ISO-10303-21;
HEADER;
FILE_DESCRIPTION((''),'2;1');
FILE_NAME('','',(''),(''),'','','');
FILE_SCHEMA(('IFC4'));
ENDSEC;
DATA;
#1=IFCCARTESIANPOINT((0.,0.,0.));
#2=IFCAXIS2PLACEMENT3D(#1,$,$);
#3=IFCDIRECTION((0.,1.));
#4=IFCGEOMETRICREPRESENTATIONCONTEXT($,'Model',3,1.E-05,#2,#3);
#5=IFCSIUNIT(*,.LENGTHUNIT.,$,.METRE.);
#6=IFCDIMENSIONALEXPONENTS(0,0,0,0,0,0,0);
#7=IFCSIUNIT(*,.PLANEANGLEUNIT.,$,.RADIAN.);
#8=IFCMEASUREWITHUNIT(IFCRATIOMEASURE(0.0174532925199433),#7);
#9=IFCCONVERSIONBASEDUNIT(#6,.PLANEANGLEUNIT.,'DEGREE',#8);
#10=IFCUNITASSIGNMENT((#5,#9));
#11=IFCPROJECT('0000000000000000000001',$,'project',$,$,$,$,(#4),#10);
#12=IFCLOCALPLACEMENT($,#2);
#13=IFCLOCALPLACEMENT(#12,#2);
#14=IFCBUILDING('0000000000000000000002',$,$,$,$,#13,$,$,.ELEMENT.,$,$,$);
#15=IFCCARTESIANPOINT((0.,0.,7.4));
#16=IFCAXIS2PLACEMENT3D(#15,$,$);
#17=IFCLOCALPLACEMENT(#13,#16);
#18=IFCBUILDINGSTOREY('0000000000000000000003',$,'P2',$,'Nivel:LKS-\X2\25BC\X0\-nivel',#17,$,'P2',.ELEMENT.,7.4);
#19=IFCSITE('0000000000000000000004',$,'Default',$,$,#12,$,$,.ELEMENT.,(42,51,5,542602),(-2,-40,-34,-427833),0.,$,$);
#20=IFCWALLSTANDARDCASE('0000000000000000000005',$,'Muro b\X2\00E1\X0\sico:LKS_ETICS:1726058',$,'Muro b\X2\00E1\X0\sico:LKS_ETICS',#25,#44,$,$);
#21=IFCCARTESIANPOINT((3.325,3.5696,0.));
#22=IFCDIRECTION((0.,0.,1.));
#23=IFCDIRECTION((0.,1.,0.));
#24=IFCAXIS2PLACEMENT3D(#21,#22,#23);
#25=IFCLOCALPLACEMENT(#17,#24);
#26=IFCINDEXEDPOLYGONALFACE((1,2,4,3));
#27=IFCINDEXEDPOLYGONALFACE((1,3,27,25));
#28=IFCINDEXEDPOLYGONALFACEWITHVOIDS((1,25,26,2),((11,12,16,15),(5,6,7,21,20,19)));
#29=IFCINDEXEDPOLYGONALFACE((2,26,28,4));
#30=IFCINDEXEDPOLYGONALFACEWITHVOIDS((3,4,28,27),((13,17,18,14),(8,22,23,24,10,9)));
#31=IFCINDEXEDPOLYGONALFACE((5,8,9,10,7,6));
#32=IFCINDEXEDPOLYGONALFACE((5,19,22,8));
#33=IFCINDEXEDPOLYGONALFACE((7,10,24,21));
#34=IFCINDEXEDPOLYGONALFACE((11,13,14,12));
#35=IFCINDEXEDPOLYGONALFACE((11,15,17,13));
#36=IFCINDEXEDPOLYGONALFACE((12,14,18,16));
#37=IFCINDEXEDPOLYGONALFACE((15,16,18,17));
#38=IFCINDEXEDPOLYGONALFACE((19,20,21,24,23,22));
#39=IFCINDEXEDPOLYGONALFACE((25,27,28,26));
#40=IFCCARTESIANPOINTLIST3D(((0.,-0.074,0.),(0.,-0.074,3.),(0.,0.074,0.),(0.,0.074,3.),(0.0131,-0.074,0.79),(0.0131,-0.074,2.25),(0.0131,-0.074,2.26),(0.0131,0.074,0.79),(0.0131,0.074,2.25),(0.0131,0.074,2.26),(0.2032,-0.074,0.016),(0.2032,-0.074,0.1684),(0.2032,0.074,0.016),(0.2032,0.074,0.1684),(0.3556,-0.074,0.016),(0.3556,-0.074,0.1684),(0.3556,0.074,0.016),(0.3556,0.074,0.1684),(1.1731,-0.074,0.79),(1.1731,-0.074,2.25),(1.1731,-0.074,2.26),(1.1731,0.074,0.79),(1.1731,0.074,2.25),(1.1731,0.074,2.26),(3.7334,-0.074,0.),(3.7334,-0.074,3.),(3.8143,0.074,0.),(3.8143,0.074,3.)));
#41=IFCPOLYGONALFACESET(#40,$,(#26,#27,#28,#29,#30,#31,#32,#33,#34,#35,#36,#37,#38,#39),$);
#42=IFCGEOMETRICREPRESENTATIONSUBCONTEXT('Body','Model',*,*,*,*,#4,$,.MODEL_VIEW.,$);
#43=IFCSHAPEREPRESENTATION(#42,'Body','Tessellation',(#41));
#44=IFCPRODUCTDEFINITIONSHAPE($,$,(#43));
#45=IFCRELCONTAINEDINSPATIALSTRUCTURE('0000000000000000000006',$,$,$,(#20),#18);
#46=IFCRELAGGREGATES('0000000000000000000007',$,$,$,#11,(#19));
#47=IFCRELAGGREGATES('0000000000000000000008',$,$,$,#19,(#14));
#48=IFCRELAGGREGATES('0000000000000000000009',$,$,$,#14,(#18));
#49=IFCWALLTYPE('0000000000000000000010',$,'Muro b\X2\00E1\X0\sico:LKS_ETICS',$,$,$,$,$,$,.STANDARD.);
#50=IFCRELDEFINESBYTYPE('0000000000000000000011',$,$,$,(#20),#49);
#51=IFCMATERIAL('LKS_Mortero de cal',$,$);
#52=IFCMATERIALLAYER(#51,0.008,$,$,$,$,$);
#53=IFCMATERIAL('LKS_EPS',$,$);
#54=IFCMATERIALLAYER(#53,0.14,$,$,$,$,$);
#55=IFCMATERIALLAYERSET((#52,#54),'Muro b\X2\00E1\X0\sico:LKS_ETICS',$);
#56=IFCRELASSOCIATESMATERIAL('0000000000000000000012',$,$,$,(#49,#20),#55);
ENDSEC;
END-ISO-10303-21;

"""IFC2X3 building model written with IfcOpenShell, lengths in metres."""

from ifc_helpers import new_model, entity, si_unit, converted_unit, direction, frame, frame_2d, origin, place, context, subcontext, project, spatial, polyline, rectangle, outline, extrude, material, layer, layer_set, layer_usage, type_object, element, save


model = new_model("IFC2X3")

# Units and contexts
model_context = context("Model", 3, precision=1e-05, world=origin(), true_north=direction((0.0, 1.0)))
body_context = subcontext(model_context, "Body", "Model", "MODEL_VIEW")
ifc_project = project(units=[si_unit("LENGTHUNIT", "METRE"), converted_unit("PLANEANGLEUNIT", "DEGREE", entity("IfcRatioMeasure", 0.0174532925199433), si_unit("PLANEANGLEUNIT", "RADIAN"), dimensions=[0, 0, 0, 0, 0, 0, 0])], contexts=[model_context])

# Site, building, storey
site_placement = place(None, origin())
site = spatial("IfcSite", under=ifc_project, at=site_placement, Name="Default", CompositionType="ELEMENT", RefLatitude=(42, 51, 5, 542602), RefLongitude=(-2, -40, -34, -427833), RefElevation=0.0)
building_placement = place(site_placement, origin())
building = spatial("IfcBuilding", under=site, at=building_placement, CompositionType="ELEMENT")
storey_placement = place(building_placement, frame((0.0, 0.0, 7.4)))
storey = spatial("IfcBuildingStorey", under=building, at=storey_placement, Name="P2", ObjectType="Nivel:LKS-▼-nivel", LongName="P2", CompositionType="ELEMENT", Elevation=7.4)

# Shared definitions
ifc_material_1 = material(Name="LKS_Mortero de cal")
ifc_layer_1 = layer(ifc_material_1, 0.008)
ifc_material_2 = material(Name="LKS_EPS")
ifc_layer_2 = layer(ifc_material_2, 0.14)
ifc_layer_set_1 = layer_set([ifc_layer_1, ifc_layer_2], Name="Muro básico:LKS_ETICS")
wall_type_1 = type_object("IfcWallType", Name="Muro básico:LKS_ETICS", PredefinedType="STANDARD", material=ifc_layer_set_1)

# Wall, openings
ifc_layer_usage_1 = layer_usage(ifc_layer_set_1, "AXIS2", "NEGATIVE", 0.074)
wall_1_placement = place(storey_placement, frame((3.325, 3.5696, 0.0), z_axis=(0.0, 0.0, 1.0), x_axis=(0.0, 1.0, 0.0)))
wall_1 = element("IfcWallStandardCase", 1, at=wall_1_placement, inside=storey, type_object=wall_type_1, material=ifc_layer_usage_1, Name="Muro básico:LKS_ETICS:1726058", ObjectType="Muro básico:LKS_ETICS", context=body_context, shape_type="SweptSolid", body=[
    extrude(outline(polyline([(3.7334, -0.074), (3.8143, 0.074), (3.6456, 0.074), (0.0, 0.074), (0.0, -0.074), (3.7334, -0.074)])), origin(), (0.0, 0.0, 1.0), 3.0),
])
opening_1_placement = place(wall_1_placement, origin())
element("IfcOpeningElement", 2, at=opening_1_placement, cuts=wall_1, ObjectType="Opening", context=body_context, shape_type="SweptSolid", body=[
    extrude(rectangle(XDim=1.46, YDim=1.16, at=frame_2d((0.0, 0.0), x_axis=(1.0, 0.0))), frame((0.5931, -1.836, 1.52), z_axis=(0.0, 1.0, 0.0), x_axis=(0.0, 0.0, 1.0)), (0.0, 0.0, 1.0), 3.048),
])
opening_2_placement = place(wall_1_placement, origin())
element("IfcOpeningElement", 3, at=opening_2_placement, cuts=wall_1, ObjectType="Opening", context=body_context, shape_type="SweptSolid", body=[
    extrude(rectangle(XDim=1.47, YDim=1.16, at=frame_2d((0.0, 0.0), x_axis=(1.0, 0.0))), frame((0.5931, -1.836, 1.525), z_axis=(0.0, 1.0, 0.0), x_axis=(0.0, 0.0, 1.0)), (0.0, 0.0, 1.0), 3.048),
])
opening_3_placement = place(wall_1_placement, origin())
element("IfcOpeningElement", 4, at=opening_3_placement, cuts=wall_1, ObjectType="Opening", context=body_context, shape_type="SweptSolid", body=[
    extrude(rectangle(XDim=0.1524, YDim=0.1524, at=frame_2d((0.0, 0.0), x_axis=(1.0, 0.0))), frame((0.2794, -1.836, 0.0922), z_axis=(0.0, 1.0, 0.0), x_axis=(0.0, 0.0, 1.0)), (0.0, 0.0, 1.0), 3.048),
])

save(model, "model.ifc")
